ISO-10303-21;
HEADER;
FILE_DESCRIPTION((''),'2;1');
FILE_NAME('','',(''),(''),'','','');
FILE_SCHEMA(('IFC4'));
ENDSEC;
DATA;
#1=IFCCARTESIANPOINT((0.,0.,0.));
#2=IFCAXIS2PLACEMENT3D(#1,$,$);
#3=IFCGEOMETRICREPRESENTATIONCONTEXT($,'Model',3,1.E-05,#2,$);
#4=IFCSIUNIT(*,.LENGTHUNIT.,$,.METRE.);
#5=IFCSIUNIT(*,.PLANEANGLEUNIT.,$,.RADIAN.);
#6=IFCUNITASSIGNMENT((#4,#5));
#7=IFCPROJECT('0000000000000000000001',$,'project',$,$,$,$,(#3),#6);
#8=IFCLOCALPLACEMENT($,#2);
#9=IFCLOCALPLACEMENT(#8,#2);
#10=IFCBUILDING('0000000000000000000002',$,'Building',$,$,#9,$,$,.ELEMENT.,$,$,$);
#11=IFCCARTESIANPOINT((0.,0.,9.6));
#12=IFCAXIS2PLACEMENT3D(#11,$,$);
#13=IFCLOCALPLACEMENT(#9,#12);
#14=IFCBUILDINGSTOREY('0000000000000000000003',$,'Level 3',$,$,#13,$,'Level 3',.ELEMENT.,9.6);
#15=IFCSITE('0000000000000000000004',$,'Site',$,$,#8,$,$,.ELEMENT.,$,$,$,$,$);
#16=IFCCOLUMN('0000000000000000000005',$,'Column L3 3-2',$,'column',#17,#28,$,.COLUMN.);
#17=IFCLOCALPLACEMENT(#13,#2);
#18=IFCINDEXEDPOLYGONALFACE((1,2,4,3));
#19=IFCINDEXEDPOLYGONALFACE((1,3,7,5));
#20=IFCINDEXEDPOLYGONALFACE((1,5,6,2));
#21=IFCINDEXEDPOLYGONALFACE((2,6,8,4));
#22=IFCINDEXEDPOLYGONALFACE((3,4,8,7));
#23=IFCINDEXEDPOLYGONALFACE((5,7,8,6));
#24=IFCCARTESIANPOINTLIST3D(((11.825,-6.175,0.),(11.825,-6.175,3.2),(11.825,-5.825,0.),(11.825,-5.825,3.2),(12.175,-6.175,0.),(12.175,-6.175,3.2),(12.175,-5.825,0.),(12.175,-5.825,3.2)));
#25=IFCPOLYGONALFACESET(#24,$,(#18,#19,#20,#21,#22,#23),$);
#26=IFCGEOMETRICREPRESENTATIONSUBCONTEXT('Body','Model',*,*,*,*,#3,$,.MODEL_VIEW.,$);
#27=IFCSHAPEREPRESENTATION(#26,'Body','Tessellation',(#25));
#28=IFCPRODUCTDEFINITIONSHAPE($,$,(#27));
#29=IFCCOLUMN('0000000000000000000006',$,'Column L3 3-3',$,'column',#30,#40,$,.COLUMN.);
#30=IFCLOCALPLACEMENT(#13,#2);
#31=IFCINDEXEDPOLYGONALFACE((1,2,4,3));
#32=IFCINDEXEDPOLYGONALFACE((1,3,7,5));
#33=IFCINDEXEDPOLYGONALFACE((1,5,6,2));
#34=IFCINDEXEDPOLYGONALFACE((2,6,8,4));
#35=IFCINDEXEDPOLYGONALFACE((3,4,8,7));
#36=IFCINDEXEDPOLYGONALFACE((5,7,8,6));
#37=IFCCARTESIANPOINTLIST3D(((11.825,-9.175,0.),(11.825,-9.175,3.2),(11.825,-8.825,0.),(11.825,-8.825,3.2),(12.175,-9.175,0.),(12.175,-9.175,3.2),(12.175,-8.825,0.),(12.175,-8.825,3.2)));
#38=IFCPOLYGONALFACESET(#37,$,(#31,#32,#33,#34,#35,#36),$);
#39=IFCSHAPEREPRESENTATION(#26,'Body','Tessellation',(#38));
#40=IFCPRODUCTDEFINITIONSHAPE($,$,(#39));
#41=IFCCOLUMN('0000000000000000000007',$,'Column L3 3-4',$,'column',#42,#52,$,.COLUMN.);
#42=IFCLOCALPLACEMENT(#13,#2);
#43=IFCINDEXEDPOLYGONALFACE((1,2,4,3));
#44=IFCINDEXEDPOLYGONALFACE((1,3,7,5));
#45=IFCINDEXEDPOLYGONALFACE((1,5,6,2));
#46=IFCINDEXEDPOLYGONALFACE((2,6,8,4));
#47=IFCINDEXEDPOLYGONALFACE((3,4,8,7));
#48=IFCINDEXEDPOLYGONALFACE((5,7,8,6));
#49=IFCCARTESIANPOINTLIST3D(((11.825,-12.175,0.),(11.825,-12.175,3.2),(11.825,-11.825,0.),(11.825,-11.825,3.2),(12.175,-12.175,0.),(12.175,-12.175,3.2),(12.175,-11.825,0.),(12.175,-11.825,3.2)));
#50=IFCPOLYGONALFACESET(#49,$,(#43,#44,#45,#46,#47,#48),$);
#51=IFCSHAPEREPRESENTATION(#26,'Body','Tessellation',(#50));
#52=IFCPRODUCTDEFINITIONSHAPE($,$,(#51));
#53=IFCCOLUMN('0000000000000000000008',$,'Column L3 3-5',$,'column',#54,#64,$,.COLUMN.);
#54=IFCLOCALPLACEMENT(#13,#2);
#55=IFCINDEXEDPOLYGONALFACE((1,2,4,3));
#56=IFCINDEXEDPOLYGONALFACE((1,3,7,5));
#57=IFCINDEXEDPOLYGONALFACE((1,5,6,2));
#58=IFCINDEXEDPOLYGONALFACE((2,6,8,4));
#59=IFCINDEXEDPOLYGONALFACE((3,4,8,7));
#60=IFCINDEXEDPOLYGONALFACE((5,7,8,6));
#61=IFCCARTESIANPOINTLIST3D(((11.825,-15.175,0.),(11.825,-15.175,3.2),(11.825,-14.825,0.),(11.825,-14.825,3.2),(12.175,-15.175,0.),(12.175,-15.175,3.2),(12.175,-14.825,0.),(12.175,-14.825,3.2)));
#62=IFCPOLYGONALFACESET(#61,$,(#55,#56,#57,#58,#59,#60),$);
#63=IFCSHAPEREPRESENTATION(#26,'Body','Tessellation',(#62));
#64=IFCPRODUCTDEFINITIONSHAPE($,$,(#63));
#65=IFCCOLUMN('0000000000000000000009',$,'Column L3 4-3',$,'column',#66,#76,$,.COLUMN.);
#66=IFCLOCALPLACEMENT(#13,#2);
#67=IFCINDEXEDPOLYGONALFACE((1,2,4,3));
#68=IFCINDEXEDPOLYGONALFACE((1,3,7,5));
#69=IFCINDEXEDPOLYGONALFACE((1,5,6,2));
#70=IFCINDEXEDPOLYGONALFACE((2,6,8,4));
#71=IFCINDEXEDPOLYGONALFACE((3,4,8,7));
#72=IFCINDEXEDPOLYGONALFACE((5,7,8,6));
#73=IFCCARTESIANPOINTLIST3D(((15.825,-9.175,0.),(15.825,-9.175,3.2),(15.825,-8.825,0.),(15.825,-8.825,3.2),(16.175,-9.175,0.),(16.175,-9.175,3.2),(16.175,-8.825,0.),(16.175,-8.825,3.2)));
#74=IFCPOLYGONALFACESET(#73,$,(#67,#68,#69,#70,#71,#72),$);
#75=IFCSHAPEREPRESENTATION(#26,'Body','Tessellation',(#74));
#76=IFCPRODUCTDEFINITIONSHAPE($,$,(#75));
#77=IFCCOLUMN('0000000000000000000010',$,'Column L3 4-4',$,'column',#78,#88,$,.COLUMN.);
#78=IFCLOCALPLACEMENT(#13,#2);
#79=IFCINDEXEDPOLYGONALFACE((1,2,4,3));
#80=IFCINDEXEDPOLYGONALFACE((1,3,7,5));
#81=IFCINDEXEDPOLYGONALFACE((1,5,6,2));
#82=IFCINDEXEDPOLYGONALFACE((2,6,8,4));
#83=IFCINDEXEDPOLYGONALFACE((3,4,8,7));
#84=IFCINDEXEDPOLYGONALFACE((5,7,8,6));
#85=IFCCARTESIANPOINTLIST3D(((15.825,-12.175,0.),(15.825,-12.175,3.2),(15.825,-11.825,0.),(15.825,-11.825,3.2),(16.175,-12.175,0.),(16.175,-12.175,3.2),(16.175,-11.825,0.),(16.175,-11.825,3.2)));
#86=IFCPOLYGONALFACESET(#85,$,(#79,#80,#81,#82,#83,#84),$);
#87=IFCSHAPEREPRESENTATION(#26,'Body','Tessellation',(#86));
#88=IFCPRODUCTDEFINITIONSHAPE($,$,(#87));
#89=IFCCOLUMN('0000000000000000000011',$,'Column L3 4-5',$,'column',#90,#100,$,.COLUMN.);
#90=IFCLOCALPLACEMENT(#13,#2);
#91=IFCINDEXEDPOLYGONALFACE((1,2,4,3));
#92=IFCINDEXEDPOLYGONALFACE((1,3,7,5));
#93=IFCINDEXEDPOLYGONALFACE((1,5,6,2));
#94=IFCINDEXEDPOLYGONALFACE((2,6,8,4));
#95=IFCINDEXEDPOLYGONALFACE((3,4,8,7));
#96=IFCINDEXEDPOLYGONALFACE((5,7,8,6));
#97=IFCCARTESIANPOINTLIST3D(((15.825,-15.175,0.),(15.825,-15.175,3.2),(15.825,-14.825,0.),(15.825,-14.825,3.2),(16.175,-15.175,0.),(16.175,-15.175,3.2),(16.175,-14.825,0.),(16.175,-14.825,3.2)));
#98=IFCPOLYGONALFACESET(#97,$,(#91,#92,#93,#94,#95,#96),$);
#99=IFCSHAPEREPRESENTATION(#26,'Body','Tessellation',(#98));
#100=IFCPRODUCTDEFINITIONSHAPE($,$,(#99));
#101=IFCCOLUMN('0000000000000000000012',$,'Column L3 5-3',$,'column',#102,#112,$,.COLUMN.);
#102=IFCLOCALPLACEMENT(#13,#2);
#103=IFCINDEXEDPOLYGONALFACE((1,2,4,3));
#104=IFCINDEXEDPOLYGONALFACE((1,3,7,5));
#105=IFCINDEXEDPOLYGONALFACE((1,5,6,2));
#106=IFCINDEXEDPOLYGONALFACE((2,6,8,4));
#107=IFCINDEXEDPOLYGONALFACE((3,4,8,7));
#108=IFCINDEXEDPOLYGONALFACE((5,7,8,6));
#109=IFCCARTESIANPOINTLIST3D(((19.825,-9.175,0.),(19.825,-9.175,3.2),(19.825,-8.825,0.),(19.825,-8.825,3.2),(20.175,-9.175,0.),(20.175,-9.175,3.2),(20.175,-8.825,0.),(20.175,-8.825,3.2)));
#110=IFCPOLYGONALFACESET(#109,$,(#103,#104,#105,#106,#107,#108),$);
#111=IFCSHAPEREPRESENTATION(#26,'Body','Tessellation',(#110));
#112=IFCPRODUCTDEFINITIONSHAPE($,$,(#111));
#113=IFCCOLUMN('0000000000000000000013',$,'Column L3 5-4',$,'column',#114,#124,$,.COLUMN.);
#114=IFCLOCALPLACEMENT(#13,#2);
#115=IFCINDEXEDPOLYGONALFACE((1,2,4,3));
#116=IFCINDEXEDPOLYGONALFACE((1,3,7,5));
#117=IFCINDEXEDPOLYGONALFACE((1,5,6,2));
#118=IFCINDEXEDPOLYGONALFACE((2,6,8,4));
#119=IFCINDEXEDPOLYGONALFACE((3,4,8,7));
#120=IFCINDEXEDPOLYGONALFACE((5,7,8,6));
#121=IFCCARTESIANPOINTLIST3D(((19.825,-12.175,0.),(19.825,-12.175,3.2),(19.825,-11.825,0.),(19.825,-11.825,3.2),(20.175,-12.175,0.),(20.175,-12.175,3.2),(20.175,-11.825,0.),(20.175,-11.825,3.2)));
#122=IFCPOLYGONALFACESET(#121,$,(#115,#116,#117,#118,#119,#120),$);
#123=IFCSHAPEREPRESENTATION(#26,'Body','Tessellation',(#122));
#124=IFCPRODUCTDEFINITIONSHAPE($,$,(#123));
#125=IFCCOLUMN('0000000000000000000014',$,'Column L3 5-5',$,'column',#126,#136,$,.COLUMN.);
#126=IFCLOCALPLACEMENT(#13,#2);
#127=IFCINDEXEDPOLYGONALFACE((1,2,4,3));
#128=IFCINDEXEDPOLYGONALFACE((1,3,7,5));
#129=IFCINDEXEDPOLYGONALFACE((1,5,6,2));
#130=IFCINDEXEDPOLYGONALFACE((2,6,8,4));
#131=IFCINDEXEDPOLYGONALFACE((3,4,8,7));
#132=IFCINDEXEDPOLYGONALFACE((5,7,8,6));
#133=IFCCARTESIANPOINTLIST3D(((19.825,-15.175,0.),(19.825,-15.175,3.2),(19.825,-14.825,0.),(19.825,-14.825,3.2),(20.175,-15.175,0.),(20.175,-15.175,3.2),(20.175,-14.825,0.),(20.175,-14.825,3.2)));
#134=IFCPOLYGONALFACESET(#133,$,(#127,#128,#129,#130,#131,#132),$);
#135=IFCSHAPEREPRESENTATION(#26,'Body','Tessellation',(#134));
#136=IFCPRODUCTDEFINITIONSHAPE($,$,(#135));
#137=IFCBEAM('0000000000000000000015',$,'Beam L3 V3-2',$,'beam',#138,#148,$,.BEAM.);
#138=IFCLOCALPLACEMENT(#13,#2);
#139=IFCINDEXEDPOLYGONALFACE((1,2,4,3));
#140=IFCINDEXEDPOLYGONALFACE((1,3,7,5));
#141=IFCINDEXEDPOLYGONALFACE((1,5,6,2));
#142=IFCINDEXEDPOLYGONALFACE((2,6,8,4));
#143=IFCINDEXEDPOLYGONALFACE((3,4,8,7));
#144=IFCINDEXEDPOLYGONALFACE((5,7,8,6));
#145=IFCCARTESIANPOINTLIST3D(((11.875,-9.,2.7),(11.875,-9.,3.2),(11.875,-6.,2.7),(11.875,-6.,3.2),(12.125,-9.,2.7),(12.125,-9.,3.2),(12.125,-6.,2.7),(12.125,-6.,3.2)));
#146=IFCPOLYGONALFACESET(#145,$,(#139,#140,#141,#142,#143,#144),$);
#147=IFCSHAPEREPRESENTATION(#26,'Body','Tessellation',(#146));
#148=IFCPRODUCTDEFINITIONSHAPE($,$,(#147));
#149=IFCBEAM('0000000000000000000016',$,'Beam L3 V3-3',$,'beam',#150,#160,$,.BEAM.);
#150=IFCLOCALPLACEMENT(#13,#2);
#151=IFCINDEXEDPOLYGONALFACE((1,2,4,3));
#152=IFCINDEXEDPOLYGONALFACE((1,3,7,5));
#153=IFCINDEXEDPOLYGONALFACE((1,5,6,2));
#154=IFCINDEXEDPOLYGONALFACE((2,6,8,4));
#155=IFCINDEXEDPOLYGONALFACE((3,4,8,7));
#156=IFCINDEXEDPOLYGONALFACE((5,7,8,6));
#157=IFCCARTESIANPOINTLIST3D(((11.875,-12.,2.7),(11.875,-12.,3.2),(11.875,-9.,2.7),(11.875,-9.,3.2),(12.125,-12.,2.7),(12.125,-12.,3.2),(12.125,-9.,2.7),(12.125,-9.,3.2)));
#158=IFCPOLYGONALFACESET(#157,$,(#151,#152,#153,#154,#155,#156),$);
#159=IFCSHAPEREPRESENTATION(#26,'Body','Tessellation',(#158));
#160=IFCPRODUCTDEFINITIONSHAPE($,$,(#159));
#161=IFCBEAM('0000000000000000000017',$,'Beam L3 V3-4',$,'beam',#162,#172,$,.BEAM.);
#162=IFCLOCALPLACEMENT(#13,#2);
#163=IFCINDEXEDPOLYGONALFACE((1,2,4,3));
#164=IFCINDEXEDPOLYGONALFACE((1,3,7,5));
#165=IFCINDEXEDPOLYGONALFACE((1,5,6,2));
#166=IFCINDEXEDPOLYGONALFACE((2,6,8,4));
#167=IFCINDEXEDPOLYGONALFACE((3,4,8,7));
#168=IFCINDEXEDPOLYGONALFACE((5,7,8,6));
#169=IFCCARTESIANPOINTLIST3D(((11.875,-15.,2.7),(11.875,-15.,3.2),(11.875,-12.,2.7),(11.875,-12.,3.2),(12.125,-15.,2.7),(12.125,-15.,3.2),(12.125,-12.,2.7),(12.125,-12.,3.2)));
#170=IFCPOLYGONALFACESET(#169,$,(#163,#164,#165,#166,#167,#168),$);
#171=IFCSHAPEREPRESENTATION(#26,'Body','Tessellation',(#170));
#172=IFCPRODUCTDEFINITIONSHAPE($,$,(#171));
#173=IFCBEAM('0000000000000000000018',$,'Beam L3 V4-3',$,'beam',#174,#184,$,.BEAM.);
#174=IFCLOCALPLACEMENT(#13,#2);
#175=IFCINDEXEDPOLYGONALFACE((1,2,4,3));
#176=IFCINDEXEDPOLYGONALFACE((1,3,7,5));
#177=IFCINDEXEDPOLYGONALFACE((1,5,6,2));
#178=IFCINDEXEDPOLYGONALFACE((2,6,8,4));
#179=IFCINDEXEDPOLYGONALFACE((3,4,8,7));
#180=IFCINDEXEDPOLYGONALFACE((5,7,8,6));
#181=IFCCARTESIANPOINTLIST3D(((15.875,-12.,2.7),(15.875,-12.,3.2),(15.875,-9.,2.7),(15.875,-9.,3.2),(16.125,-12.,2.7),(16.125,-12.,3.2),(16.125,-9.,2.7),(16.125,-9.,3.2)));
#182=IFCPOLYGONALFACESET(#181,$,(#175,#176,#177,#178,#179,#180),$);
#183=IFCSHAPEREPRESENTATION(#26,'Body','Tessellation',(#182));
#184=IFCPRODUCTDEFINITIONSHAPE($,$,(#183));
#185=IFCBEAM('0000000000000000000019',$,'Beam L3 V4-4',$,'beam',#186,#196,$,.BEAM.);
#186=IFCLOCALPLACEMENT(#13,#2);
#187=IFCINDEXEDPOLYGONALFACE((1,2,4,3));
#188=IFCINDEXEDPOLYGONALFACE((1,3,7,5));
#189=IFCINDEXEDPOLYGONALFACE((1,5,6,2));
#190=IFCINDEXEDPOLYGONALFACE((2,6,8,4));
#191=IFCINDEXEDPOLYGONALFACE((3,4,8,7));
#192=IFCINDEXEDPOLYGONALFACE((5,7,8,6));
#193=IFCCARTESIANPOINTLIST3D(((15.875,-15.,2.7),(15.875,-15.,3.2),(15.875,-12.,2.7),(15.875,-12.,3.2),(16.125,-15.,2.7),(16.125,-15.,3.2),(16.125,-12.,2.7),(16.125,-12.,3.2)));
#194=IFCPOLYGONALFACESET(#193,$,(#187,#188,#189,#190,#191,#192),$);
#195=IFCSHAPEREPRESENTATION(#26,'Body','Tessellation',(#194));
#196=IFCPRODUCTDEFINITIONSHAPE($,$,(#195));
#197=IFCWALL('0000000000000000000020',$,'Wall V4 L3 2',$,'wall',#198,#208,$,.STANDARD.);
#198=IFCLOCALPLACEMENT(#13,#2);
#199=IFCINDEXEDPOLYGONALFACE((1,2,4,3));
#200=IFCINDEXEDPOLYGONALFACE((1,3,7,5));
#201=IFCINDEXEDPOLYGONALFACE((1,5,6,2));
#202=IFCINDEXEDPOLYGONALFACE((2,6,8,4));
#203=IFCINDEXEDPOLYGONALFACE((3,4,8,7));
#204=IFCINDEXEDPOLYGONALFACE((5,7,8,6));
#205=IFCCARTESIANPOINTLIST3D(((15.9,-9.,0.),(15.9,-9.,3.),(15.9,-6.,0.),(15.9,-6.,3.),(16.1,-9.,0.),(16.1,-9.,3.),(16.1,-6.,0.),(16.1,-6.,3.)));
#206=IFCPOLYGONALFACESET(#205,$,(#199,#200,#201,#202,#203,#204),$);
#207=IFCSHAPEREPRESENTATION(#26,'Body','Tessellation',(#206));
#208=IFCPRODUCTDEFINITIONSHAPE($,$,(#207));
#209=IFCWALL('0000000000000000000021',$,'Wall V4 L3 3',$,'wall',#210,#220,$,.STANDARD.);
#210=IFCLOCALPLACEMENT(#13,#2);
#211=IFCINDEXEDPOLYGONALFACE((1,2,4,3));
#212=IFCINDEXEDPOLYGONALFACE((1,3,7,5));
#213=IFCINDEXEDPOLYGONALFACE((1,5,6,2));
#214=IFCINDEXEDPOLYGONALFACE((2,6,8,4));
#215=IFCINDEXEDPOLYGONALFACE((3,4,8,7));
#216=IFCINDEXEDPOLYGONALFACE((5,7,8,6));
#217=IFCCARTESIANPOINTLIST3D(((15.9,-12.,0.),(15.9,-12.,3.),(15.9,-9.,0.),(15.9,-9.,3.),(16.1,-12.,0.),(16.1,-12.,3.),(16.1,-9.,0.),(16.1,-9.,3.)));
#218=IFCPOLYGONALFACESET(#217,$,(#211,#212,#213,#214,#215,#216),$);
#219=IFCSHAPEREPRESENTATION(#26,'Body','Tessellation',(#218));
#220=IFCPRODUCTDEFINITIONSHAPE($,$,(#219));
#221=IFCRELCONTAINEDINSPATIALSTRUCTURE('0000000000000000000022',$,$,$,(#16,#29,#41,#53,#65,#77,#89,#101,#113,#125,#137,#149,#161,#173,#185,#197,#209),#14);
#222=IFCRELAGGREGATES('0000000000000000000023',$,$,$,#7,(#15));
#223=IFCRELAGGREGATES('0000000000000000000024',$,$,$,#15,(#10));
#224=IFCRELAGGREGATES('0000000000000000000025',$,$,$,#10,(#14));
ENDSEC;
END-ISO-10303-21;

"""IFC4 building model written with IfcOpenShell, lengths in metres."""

from ifc_helpers import new_model, si_unit, frame, frame_2d, origin, origin_2d, place, context, subcontext, project, spatial, rectangle, extrude, element, save


model = new_model("IFC4")

# Units and contexts
model_context = context("Model", 3, precision=1e-05, world=origin())
body_context = subcontext(model_context, "Body", "Model", "MODEL_VIEW")
ifc_project = project(units=[si_unit("LENGTHUNIT", "METRE"), si_unit("PLANEANGLEUNIT", "RADIAN")], contexts=[model_context])

# Site, building, storey
site_placement = place(None, origin())
site = spatial("IfcSite", under=ifc_project, at=site_placement, Name="Site", CompositionType="ELEMENT")
building_placement = place(site_placement, origin())
building = spatial("IfcBuilding", under=site, at=building_placement, Name="Building", CompositionType="ELEMENT")
storey_placement = place(building_placement, frame((0.0, 0.0, 9.6)))
storey = spatial("IfcBuildingStorey", under=building, at=storey_placement, Name="Level 3", LongName="Level 3", CompositionType="ELEMENT", Elevation=9.6)

# Columns
for number, where, name in (
    (1, (12.0, -6.0, 0.0), "Column L3 3-2"),
    (2, (12.0, -9.0, 0.0), "Column L3 3-3"),
    (3, (12.0, -12.0, 0.0), "Column L3 3-4"),
    (4, (12.0, -15.0, 0.0), "Column L3 3-5"),
    (5, (16.0, -9.0, 0.0), "Column L3 4-3"),
    (6, (16.0, -12.0, 0.0), "Column L3 4-4"),
    (7, (16.0, -15.0, 0.0), "Column L3 4-5"),
    (8, (20.0, -9.0, 0.0), "Column L3 5-3"),
    (9, (20.0, -12.0, 0.0), "Column L3 5-4"),
    (10, (20.0, -15.0, 0.0), "Column L3 5-5"),
):
    element("IfcColumn", number, at=place(storey_placement, frame(where)), inside=storey, Name=name, ObjectType="column", PredefinedType="COLUMN", context=body_context, shape_type="SweptSolid", body=[
        extrude(rectangle(XDim=0.35, YDim=0.35, at=origin_2d()), origin(), (0.0, 0.0, 1.0), 3.2),
    ])

# Beams
for number, where, z_axis, x_axis, name in (
    (11, (12.0, -6.0, 2.95), (0.0, -1.0, 0.0), (0.0, 0.0, 1.0), "Beam L3 V3-2"),
    (12, (12.0, -9.0, 2.95), (0.0, -1.0, 0.0), (0.0, 0.0, 1.0), "Beam L3 V3-3"),
    (13, (12.0, -12.0, 2.95), (0.0, -1.0, 0.0), (0.0, 0.0, 1.0), "Beam L3 V3-4"),
    (14, (16.0, -9.0, 2.95), (0.0, -1.0, 0.0), (0.0, 0.0, 1.0), "Beam L3 V4-3"),
    (15, (16.0, -12.0, 2.95), (0.0, -1.0, 0.0), (0.0, 0.0, 1.0), "Beam L3 V4-4"),
):
    element("IfcBeam", number, at=place(storey_placement, frame(where, z_axis=z_axis, x_axis=x_axis)), inside=storey, Name=name, ObjectType="beam", PredefinedType="BEAM", context=body_context, shape_type="SweptSolid", body=[
        extrude(rectangle(XDim=0.5, YDim=0.25, at=origin_2d()), origin(), (0.0, 0.0, 1.0), 3.0),
    ])

# Walls
for number, where, z_axis, x_axis, name in (
    (16, (16.0, -6.0, 0.0), (0.0, 0.0, 1.0), (0.0, -1.0, 0.0), "Wall V4 L3 2"),
    (17, (16.0, -9.0, 0.0), (0.0, 0.0, 1.0), (0.0, -1.0, 0.0), "Wall V4 L3 3"),
):
    element("IfcWall", number, at=place(storey_placement, frame(where, z_axis=z_axis, x_axis=x_axis)), inside=storey, Name=name, ObjectType="wall", PredefinedType="STANDARD", context=body_context, shape_type="SweptSolid", body=[
        extrude(rectangle(XDim=3.0, YDim=0.2, at=frame_2d((1.5, 0.0))), origin(), (0.0, 0.0, 1.0), 3.0),
    ])

save(model, "model.ifc")
